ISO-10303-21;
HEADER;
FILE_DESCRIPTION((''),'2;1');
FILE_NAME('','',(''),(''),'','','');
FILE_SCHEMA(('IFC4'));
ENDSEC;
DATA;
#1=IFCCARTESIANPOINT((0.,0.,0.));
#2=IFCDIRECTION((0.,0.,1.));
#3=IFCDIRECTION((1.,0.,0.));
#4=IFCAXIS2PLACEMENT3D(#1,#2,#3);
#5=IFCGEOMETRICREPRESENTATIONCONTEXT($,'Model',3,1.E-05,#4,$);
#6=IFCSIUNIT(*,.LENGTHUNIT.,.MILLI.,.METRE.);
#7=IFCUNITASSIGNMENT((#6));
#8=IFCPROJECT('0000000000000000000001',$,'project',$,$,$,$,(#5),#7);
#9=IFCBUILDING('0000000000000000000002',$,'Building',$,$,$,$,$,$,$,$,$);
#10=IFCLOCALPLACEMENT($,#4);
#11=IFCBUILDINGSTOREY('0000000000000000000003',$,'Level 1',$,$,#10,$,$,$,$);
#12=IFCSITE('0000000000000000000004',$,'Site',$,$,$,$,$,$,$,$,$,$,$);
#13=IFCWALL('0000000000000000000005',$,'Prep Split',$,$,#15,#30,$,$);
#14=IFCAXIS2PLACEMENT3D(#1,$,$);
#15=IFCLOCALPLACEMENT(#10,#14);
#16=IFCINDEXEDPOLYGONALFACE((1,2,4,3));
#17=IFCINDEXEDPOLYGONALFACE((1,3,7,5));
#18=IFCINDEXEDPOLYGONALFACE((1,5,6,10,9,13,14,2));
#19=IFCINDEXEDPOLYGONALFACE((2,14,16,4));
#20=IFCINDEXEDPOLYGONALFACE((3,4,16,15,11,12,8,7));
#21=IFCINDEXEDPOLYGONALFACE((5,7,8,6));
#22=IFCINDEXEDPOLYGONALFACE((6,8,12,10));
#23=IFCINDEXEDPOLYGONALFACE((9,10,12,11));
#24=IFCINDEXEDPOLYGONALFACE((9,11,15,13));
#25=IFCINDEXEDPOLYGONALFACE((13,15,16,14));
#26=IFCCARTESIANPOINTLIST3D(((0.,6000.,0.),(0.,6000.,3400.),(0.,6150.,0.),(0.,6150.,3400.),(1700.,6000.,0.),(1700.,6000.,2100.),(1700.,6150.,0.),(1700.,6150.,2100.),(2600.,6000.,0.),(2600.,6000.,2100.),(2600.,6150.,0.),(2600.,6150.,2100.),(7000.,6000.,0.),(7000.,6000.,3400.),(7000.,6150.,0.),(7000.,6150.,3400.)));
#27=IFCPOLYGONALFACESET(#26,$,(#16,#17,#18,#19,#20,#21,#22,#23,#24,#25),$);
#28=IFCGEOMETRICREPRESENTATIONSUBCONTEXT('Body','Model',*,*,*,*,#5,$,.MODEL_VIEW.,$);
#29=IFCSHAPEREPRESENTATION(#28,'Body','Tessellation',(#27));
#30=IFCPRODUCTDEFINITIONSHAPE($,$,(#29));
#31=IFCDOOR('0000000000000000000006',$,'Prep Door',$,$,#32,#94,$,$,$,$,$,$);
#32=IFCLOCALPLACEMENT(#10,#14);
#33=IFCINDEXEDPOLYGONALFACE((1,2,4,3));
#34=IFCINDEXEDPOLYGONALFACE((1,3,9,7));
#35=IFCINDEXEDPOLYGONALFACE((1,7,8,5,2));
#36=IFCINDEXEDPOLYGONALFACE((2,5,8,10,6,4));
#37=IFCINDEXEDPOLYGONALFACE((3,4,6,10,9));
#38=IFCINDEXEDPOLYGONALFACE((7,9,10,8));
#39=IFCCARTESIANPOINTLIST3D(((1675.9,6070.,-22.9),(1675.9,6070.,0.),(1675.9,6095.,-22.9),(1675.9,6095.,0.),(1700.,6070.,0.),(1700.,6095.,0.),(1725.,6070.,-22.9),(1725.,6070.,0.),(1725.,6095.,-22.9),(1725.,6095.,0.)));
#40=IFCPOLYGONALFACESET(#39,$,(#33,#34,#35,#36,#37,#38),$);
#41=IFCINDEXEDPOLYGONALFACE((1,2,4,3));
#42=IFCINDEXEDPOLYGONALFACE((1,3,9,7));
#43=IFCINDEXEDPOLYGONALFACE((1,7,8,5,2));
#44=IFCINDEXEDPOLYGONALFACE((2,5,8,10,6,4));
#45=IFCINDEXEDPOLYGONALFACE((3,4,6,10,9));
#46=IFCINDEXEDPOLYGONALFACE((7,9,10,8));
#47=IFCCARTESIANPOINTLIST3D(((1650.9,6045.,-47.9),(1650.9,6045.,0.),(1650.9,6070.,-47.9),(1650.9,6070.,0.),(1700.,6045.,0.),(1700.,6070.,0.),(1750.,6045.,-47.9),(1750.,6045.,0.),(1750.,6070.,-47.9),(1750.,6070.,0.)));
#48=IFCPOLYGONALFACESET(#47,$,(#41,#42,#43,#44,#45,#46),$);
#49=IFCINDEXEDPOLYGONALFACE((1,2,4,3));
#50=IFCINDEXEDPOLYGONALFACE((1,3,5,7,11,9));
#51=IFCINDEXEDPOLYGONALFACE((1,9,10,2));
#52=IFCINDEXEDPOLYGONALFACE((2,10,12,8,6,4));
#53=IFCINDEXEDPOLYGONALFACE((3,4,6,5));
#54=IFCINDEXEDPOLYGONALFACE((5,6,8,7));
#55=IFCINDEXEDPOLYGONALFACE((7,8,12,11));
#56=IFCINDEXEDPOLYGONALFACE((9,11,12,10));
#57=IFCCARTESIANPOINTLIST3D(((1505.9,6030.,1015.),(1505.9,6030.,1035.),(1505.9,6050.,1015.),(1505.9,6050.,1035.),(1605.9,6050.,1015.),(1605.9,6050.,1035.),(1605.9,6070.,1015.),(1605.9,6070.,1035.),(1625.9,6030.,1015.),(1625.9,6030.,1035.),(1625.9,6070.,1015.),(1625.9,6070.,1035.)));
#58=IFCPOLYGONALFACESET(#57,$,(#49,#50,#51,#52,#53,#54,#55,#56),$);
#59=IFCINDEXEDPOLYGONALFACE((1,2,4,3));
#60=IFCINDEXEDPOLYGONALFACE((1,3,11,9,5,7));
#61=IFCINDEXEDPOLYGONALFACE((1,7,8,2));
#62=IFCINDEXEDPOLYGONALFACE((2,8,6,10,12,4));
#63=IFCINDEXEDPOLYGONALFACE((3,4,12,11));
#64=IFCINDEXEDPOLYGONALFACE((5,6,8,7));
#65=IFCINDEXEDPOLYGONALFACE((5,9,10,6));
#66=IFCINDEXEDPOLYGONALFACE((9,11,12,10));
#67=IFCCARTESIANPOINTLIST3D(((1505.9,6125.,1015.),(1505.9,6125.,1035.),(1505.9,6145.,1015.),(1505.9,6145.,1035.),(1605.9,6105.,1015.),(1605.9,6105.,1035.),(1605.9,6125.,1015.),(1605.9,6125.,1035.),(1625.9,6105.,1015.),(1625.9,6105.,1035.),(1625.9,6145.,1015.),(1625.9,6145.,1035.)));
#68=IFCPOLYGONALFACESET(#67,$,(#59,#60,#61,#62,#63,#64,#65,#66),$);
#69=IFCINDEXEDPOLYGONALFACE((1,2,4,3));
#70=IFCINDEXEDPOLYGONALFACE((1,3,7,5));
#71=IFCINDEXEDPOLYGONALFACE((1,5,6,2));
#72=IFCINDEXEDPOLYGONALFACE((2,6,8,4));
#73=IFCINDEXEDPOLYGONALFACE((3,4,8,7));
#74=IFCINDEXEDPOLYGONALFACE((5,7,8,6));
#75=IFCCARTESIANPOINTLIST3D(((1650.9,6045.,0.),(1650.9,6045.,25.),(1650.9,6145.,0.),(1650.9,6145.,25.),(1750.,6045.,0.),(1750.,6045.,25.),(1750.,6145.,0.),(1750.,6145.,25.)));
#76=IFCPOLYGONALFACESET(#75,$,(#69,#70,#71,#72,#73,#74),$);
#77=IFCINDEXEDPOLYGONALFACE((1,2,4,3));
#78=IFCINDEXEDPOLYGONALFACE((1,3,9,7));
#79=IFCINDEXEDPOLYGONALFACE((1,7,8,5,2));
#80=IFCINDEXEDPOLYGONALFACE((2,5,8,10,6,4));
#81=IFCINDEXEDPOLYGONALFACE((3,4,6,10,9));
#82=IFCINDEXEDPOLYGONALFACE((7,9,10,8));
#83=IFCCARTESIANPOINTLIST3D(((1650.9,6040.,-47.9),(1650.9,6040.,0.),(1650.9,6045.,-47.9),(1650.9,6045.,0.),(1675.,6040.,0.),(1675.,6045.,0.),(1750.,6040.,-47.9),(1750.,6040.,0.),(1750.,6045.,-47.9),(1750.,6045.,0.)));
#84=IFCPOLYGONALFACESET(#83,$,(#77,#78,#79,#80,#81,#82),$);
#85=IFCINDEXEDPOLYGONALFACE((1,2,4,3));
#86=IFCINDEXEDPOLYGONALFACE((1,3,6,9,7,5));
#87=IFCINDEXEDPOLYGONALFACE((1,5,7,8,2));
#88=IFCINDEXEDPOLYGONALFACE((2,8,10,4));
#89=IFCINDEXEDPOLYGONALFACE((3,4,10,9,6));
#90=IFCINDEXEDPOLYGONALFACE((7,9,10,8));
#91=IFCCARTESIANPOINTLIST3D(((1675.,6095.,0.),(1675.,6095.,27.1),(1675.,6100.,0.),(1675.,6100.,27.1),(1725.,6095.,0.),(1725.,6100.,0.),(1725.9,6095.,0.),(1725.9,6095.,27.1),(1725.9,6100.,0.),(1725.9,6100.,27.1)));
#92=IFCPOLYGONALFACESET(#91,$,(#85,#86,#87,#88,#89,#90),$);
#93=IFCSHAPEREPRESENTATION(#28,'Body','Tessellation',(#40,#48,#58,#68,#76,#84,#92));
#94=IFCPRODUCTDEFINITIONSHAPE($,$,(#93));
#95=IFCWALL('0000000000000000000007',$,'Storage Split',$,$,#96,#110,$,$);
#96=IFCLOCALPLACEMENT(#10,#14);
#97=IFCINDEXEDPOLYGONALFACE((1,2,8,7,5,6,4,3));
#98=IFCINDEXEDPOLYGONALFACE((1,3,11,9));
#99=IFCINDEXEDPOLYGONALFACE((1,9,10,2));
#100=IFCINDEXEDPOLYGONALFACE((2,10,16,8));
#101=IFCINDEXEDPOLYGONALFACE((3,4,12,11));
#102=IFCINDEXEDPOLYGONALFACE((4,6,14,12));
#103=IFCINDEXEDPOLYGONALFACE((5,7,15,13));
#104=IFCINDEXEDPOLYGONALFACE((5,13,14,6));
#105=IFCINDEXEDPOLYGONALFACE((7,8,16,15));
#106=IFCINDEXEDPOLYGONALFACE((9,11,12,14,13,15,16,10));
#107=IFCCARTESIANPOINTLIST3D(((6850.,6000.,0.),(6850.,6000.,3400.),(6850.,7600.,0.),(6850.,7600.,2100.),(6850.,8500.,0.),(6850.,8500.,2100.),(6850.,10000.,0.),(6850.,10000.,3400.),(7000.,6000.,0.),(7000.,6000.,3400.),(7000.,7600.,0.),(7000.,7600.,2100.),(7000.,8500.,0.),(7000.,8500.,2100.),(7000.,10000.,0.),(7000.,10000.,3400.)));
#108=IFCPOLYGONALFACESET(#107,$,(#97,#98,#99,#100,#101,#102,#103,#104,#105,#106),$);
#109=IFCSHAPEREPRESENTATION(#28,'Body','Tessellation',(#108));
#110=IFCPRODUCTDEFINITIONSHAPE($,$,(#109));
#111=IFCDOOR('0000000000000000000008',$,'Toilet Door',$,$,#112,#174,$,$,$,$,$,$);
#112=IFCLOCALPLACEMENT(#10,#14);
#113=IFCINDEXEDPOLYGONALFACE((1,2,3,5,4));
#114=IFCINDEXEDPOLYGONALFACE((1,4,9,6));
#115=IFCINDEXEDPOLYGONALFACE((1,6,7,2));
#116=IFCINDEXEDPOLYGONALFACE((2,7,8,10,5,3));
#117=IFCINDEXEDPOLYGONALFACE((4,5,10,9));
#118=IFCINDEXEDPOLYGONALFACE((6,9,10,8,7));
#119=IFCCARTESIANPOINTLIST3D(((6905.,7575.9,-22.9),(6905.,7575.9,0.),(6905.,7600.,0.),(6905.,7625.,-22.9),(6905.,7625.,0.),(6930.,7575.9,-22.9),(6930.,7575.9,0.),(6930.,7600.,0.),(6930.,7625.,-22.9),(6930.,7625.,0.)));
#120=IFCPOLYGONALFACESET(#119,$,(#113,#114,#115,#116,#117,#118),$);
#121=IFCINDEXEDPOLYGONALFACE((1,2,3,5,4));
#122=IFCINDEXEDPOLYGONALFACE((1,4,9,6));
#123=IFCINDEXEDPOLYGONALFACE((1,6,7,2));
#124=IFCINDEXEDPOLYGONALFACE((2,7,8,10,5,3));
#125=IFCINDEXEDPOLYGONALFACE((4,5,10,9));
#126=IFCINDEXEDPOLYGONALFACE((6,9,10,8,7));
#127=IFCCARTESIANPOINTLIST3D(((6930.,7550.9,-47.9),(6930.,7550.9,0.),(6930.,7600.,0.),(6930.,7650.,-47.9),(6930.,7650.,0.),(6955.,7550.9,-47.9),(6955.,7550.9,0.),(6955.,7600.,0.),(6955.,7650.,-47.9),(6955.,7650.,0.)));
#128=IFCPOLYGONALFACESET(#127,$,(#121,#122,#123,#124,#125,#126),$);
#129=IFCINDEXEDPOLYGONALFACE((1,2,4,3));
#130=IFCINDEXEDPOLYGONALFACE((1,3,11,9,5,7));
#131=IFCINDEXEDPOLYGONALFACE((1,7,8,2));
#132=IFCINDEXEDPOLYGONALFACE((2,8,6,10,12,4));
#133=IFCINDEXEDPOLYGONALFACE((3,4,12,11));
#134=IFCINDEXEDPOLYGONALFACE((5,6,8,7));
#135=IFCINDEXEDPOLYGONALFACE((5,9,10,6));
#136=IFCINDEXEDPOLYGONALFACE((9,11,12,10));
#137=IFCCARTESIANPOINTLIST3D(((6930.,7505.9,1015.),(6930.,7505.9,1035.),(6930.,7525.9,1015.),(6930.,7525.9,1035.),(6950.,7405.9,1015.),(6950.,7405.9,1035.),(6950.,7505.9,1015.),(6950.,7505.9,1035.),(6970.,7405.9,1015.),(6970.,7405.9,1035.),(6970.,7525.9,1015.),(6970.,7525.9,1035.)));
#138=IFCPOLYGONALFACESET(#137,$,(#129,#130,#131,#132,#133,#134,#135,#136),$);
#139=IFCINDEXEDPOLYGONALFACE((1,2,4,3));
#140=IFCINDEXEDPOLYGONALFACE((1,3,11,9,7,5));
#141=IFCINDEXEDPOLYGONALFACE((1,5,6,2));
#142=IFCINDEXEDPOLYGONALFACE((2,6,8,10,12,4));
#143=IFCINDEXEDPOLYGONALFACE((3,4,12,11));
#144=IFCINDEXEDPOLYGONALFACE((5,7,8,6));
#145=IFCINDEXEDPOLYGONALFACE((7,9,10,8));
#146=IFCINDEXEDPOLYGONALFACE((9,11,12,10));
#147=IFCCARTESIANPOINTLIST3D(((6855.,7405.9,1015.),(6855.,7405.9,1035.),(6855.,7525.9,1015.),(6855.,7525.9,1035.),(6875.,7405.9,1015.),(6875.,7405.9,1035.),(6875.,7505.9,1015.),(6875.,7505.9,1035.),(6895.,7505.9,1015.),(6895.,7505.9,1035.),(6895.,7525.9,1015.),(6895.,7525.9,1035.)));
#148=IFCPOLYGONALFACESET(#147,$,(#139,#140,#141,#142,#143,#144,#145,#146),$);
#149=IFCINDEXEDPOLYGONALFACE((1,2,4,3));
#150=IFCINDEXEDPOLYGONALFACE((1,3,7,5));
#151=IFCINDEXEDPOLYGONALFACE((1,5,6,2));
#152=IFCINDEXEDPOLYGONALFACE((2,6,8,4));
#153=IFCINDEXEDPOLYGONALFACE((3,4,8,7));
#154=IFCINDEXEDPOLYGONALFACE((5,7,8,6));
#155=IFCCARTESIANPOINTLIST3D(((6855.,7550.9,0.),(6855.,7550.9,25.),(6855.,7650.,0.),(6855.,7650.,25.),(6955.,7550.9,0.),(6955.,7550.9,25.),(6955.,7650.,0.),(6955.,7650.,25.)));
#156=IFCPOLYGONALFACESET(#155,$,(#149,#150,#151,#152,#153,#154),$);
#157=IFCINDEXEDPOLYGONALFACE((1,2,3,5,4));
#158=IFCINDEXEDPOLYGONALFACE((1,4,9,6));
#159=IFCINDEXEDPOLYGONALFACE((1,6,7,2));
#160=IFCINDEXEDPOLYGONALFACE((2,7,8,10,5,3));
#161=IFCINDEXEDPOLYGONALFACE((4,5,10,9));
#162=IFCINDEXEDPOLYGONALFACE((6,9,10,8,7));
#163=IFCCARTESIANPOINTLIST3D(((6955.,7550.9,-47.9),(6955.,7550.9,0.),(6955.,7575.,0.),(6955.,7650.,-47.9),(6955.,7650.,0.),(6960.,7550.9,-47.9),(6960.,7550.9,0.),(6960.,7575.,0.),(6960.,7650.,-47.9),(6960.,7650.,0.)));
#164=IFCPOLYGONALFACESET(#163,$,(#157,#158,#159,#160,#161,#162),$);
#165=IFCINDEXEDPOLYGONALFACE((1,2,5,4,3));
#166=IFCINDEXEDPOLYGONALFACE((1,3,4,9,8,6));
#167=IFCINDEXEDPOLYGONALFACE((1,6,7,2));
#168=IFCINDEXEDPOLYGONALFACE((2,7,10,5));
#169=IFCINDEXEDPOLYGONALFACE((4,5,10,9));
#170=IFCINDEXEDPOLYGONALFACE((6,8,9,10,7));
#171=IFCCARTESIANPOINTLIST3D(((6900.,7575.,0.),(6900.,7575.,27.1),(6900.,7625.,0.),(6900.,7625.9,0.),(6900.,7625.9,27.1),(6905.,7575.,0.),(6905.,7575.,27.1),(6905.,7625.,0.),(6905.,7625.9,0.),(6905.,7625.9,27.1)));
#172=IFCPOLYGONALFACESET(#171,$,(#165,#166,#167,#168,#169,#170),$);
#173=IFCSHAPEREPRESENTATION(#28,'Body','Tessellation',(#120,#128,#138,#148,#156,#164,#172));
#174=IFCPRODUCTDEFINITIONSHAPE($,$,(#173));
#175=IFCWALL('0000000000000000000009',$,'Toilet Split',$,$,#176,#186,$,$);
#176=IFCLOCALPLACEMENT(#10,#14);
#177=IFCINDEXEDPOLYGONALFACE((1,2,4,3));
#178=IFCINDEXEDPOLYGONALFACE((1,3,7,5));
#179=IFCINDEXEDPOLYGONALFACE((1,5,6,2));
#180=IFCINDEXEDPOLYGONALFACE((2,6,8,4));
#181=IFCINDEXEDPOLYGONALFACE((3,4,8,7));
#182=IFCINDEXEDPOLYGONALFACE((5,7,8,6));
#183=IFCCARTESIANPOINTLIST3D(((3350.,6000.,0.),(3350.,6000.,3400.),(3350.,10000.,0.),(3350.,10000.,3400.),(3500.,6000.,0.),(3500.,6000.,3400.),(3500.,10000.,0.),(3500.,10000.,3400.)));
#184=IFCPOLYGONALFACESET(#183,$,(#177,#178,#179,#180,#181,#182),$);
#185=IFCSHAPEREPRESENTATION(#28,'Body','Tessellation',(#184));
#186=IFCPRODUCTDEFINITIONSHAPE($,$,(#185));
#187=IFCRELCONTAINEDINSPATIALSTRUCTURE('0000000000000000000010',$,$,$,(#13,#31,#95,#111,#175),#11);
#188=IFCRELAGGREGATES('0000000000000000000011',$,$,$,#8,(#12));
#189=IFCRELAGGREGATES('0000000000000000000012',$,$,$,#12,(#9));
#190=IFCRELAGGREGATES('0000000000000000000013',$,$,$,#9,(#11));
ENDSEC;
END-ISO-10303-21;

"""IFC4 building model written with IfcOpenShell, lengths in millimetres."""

from ifc_helpers import new_model, si_unit, frame, origin_with_axes, place, context, subcontext, project, spatial, line, indexed_curve, outline, extrude, element, fill, save


model = new_model("IFC4")

# Units and contexts
model_context = context("Model", 3, precision=1e-05, world=origin_with_axes())
body_context = subcontext(model_context, "Body", "Model", "MODEL_VIEW")
ifc_project = project(units=[si_unit("LENGTHUNIT", "METRE", prefix="MILLI")], contexts=[model_context])

# Site, building, storey
site = spatial("IfcSite", under=ifc_project, Name="Site")
building = spatial("IfcBuilding", under=site, Name="Building")
storey_placement = place(None, origin_with_axes())
storey = spatial("IfcBuildingStorey", under=building, at=storey_placement, Name="Level 1")

# Walls, openings, doors
wall_1_placement = place(storey_placement, frame((0.0, 6000.0, 0.0), z_axis=(0.0, 0.0, 1.0), x_axis=(1.0, 0.0, 0.0)))
wall_1 = element("IfcWall", 1, at=wall_1_placement, inside=storey, Name="Prep Split", context=body_context, shape_type="SweptSolid", body=[
    extrude(outline(indexed_curve([(0.0, 0.0), (0.0, 150.0), (7000.0, 150.0), (7000.0, 0.0), (0.0, 0.0)], self_intersect=False)), origin_with_axes(), (0.0, 0.0, 1.0), 3400.0),
])
opening_1_placement = place(wall_1_placement, frame((1700.0, -100.0, 0.0), z_axis=(0.0, 0.0, 1.0), x_axis=(1.0, 0.0, 0.0)))
opening_1 = element("IfcOpeningElement", 2, at=opening_1_placement, cuts=wall_1, context=body_context, shape_type="SweptSolid", body=[
    extrude(outline(indexed_curve([(0.0, 0.0), (0.0, 350.0), (900.0, 350.0), (900.0, 0.0), (0.0, 0.0)], self_intersect=False)), origin_with_axes(), (0.0, 0.0, 1.0), 2100.0),
])
door_1_placement = place(opening_1_placement, frame((0.0, 145.0, 0.0), z_axis=(0.0, 0.0, 1.0), x_axis=(1.0, 0.0, 0.0)))
door_1 = element("IfcDoor", 3, at=door_1_placement, inside=storey, Name="Prep Door", context=body_context, shape_type="SweptSolid", body=[
    extrude(outline(indexed_curve([(0.0, 0.0), (0.0, 2.1), (0.9, 2.1), (0.9, 0.0), (-24.1, 0.0), (-24.1, -22.9), (25.0, -22.9), (25.0, 0.0)], segments=[line(1, 2, 3, 4, 5, 6, 7, 8, 1)])), frame((0.0, 25.0, 0.0), z_axis=(0.0, -1.0, 0.0), x_axis=(1.0, 0.0, 0.0)), (0.0, 0.0, -1.0), 25.0),
    extrude(outline(indexed_curve([(0.0, 0.0), (0.0, 2.1), (0.9, 2.1), (0.9, 0.0), (-49.1, 0.0), (-49.1, -47.9), (50.0, -47.9), (50.0, 0.0)], segments=[line(1, 2, 3, 4, 5, 6, 7, 8, 1)])), frame((0.0, 0.0, 0.0), z_axis=(0.0, -1.0, 0.0), x_axis=(1.0, 0.0, 0.0)), (0.0, 0.0, -1.0), 25.0),
    extrude(outline(indexed_curve([(0.0, 0.0), (-49.1, 0.0), (-49.1, 35.0), (0.0, 35.0)], segments=[line(1, 2, 3, 4, 1)])), frame((25.0, 25.0, 25.0), z_axis=(0.0, 0.0, 1.0), x_axis=(1.0, 0.0, 0.0)), (0.0, 0.0, 1.0), -47.9),
    extrude(outline(indexed_curve([(0.0, 0.0), (0.0, -40.0), (-120.0, -40.0), (-120.0, -20.0), (-20.0, -20.0), (-20.0, 0.0)], segments=[line(1, 2, 3, 4, 5, 6, 1)])), frame((-74.1, 25.0, 1015.0), z_axis=(0.0, 0.0, 1.0), x_axis=(1.0, 0.0, 0.0)), (0.0, 0.0, 1.0), 20.0),
    extrude(outline(indexed_curve([(0.0, 0.0), (0.0, 40.0), (-120.0, 40.0), (-120.0, 20.0), (-20.0, 20.0), (-20.0, 0.0)], segments=[line(1, 2, 3, 4, 5, 6, 1)])), frame((-74.1, 60.0, 1015.0), z_axis=(0.0, 0.0, 1.0), x_axis=(1.0, 0.0, 0.0)), (0.0, 0.0, 1.0), 20.0),
    extrude(outline(indexed_curve([(0.0, 0.0), (-99.1, 0.0), (-99.1, 100.0), (0.0, 100.0)], segments=[line(1, 2, 3, 4, 1)])), frame((50.0, 0.0, 0.0), z_axis=(0.0, 0.0, 1.0), x_axis=(1.0, 0.0, 0.0)), (0.0, 0.0, 1.0), 25.0),
    extrude(outline(indexed_curve([(0.0, 0.0), (0.0, 27.1), (50.9, 27.1), (50.9, 0.0), (-24.1, 0.0), (-24.1, -47.9), (75.0, -47.9), (75.0, 0.0)], segments=[line(1, 2, 3, 4, 5, 6, 7, 8, 1)])), frame((-25.0, -5.0, 0.0), z_axis=(0.0, -1.0, 0.0), x_axis=(1.0, 0.0, 0.0)), (0.0, 0.0, -1.0), 5.0),
    extrude(outline(indexed_curve([(0.0, 0.0), (0.0, 27.1), (50.9, 27.1), (50.9, 0.0), (0.9, 0.0), (0.9, -22.9), (50.0, -22.9), (50.0, 0.0)], segments=[line(1, 2, 3, 4, 5, 6, 7, 8, 1)])), frame((-25.0, 50.0, 0.0), z_axis=(0.0, -1.0, 0.0), x_axis=(1.0, 0.0, 0.0)), (0.0, 0.0, -1.0), 5.0),
])
fill(opening_1, door_1)
wall_2_placement = place(storey_placement, frame((7000.0, 6000.0, 0.0), z_axis=(0.0, 0.0, 1.0), x_axis=(0.0, 1.0, 0.0)))
wall_2 = element("IfcWall", 4, at=wall_2_placement, inside=storey, Name="Storage Split", context=body_context, shape_type="SweptSolid", body=[
    extrude(outline(indexed_curve([(0.0, 0.0), (0.0, 150.0), (4000.0, 150.0), (4000.0, 0.0), (0.0, 0.0)], self_intersect=False)), origin_with_axes(), (0.0, 0.0, 1.0), 3400.0),
])
opening_2_placement = place(wall_2_placement, frame((1600.0, -100.0, 0.0), z_axis=(0.0, 0.0, 1.0), x_axis=(1.0, 0.0, 0.0)))
opening_2 = element("IfcOpeningElement", 5, at=opening_2_placement, cuts=wall_2, context=body_context, shape_type="SweptSolid", body=[
    extrude(outline(indexed_curve([(0.0, 0.0), (0.0, 350.0), (900.0, 350.0), (900.0, 0.0), (0.0, 0.0)], self_intersect=False)), origin_with_axes(), (0.0, 0.0, 1.0), 2100.0),
])
door_2_placement = place(opening_2_placement, frame((0.0, 145.0, 0.0), z_axis=(0.0, 0.0, 1.0), x_axis=(1.0, 0.0, 0.0)))
door_2 = element("IfcDoor", 6, at=door_2_placement, inside=storey, Name="Toilet Door", context=body_context, shape_type="SweptSolid", body=[
    extrude(outline(indexed_curve([(0.0, 0.0), (0.0, 2.1), (0.9, 2.1), (0.9, 0.0), (-24.1, 0.0), (-24.1, -22.9), (25.0, -22.9), (25.0, 0.0)], segments=[line(1, 2, 3, 4, 5, 6, 7, 8, 1)])), frame((0.0, 25.0, 0.0), z_axis=(0.0, -1.0, 0.0), x_axis=(1.0, 0.0, 0.0)), (0.0, 0.0, -1.0), 25.0),
    extrude(outline(indexed_curve([(0.0, 0.0), (0.0, 2.1), (0.9, 2.1), (0.9, 0.0), (-49.1, 0.0), (-49.1, -47.9), (50.0, -47.9), (50.0, 0.0)], segments=[line(1, 2, 3, 4, 5, 6, 7, 8, 1)])), frame((0.0, 0.0, 0.0), z_axis=(0.0, -1.0, 0.0), x_axis=(1.0, 0.0, 0.0)), (0.0, 0.0, -1.0), 25.0),
    extrude(outline(indexed_curve([(0.0, 0.0), (-49.1, 0.0), (-49.1, 35.0), (0.0, 35.0)], segments=[line(1, 2, 3, 4, 1)])), frame((25.0, 25.0, 25.0), z_axis=(0.0, 0.0, 1.0), x_axis=(1.0, 0.0, 0.0)), (0.0, 0.0, 1.0), -47.9),
    extrude(outline(indexed_curve([(0.0, 0.0), (0.0, -40.0), (-120.0, -40.0), (-120.0, -20.0), (-20.0, -20.0), (-20.0, 0.0)], segments=[line(1, 2, 3, 4, 5, 6, 1)])), frame((-74.1, 25.0, 1015.0), z_axis=(0.0, 0.0, 1.0), x_axis=(1.0, 0.0, 0.0)), (0.0, 0.0, 1.0), 20.0),
    extrude(outline(indexed_curve([(0.0, 0.0), (0.0, 40.0), (-120.0, 40.0), (-120.0, 20.0), (-20.0, 20.0), (-20.0, 0.0)], segments=[line(1, 2, 3, 4, 5, 6, 1)])), frame((-74.1, 60.0, 1015.0), z_axis=(0.0, 0.0, 1.0), x_axis=(1.0, 0.0, 0.0)), (0.0, 0.0, 1.0), 20.0),
    extrude(outline(indexed_curve([(0.0, 0.0), (-99.1, 0.0), (-99.1, 100.0), (0.0, 100.0)], segments=[line(1, 2, 3, 4, 1)])), frame((50.0, 0.0, 0.0), z_axis=(0.0, 0.0, 1.0), x_axis=(1.0, 0.0, 0.0)), (0.0, 0.0, 1.0), 25.0),
    extrude(outline(indexed_curve([(0.0, 0.0), (0.0, 27.1), (50.9, 27.1), (50.9, 0.0), (-24.1, 0.0), (-24.1, -47.9), (75.0, -47.9), (75.0, 0.0)], segments=[line(1, 2, 3, 4, 5, 6, 7, 8, 1)])), frame((-25.0, -5.0, 0.0), z_axis=(0.0, -1.0, 0.0), x_axis=(1.0, 0.0, 0.0)), (0.0, 0.0, -1.0), 5.0),
    extrude(outline(indexed_curve([(0.0, 0.0), (0.0, 27.1), (50.9, 27.1), (50.9, 0.0), (0.9, 0.0), (0.9, -22.9), (50.0, -22.9), (50.0, 0.0)], segments=[line(1, 2, 3, 4, 5, 6, 7, 8, 1)])), frame((-25.0, 50.0, 0.0), z_axis=(0.0, -1.0, 0.0), x_axis=(1.0, 0.0, 0.0)), (0.0, 0.0, -1.0), 5.0),
])
fill(opening_2, door_2)

# Wall
wall_3_placement = place(storey_placement, frame((3500.0, 6000.0, 0.0), z_axis=(0.0, 0.0, 1.0), x_axis=(0.0, 1.0, 0.0)))
element("IfcWall", 7, at=wall_3_placement, inside=storey, Name="Toilet Split", context=body_context, shape_type="SweptSolid", body=[
    extrude(outline(indexed_curve([(0.0, 0.0), (0.0, 150.0), (4000.0, 150.0), (4000.0, 0.0), (0.0, 0.0)], self_intersect=False)), origin_with_axes(), (0.0, 0.0, 1.0), 3400.0),
])

save(model, "model.ifc")
